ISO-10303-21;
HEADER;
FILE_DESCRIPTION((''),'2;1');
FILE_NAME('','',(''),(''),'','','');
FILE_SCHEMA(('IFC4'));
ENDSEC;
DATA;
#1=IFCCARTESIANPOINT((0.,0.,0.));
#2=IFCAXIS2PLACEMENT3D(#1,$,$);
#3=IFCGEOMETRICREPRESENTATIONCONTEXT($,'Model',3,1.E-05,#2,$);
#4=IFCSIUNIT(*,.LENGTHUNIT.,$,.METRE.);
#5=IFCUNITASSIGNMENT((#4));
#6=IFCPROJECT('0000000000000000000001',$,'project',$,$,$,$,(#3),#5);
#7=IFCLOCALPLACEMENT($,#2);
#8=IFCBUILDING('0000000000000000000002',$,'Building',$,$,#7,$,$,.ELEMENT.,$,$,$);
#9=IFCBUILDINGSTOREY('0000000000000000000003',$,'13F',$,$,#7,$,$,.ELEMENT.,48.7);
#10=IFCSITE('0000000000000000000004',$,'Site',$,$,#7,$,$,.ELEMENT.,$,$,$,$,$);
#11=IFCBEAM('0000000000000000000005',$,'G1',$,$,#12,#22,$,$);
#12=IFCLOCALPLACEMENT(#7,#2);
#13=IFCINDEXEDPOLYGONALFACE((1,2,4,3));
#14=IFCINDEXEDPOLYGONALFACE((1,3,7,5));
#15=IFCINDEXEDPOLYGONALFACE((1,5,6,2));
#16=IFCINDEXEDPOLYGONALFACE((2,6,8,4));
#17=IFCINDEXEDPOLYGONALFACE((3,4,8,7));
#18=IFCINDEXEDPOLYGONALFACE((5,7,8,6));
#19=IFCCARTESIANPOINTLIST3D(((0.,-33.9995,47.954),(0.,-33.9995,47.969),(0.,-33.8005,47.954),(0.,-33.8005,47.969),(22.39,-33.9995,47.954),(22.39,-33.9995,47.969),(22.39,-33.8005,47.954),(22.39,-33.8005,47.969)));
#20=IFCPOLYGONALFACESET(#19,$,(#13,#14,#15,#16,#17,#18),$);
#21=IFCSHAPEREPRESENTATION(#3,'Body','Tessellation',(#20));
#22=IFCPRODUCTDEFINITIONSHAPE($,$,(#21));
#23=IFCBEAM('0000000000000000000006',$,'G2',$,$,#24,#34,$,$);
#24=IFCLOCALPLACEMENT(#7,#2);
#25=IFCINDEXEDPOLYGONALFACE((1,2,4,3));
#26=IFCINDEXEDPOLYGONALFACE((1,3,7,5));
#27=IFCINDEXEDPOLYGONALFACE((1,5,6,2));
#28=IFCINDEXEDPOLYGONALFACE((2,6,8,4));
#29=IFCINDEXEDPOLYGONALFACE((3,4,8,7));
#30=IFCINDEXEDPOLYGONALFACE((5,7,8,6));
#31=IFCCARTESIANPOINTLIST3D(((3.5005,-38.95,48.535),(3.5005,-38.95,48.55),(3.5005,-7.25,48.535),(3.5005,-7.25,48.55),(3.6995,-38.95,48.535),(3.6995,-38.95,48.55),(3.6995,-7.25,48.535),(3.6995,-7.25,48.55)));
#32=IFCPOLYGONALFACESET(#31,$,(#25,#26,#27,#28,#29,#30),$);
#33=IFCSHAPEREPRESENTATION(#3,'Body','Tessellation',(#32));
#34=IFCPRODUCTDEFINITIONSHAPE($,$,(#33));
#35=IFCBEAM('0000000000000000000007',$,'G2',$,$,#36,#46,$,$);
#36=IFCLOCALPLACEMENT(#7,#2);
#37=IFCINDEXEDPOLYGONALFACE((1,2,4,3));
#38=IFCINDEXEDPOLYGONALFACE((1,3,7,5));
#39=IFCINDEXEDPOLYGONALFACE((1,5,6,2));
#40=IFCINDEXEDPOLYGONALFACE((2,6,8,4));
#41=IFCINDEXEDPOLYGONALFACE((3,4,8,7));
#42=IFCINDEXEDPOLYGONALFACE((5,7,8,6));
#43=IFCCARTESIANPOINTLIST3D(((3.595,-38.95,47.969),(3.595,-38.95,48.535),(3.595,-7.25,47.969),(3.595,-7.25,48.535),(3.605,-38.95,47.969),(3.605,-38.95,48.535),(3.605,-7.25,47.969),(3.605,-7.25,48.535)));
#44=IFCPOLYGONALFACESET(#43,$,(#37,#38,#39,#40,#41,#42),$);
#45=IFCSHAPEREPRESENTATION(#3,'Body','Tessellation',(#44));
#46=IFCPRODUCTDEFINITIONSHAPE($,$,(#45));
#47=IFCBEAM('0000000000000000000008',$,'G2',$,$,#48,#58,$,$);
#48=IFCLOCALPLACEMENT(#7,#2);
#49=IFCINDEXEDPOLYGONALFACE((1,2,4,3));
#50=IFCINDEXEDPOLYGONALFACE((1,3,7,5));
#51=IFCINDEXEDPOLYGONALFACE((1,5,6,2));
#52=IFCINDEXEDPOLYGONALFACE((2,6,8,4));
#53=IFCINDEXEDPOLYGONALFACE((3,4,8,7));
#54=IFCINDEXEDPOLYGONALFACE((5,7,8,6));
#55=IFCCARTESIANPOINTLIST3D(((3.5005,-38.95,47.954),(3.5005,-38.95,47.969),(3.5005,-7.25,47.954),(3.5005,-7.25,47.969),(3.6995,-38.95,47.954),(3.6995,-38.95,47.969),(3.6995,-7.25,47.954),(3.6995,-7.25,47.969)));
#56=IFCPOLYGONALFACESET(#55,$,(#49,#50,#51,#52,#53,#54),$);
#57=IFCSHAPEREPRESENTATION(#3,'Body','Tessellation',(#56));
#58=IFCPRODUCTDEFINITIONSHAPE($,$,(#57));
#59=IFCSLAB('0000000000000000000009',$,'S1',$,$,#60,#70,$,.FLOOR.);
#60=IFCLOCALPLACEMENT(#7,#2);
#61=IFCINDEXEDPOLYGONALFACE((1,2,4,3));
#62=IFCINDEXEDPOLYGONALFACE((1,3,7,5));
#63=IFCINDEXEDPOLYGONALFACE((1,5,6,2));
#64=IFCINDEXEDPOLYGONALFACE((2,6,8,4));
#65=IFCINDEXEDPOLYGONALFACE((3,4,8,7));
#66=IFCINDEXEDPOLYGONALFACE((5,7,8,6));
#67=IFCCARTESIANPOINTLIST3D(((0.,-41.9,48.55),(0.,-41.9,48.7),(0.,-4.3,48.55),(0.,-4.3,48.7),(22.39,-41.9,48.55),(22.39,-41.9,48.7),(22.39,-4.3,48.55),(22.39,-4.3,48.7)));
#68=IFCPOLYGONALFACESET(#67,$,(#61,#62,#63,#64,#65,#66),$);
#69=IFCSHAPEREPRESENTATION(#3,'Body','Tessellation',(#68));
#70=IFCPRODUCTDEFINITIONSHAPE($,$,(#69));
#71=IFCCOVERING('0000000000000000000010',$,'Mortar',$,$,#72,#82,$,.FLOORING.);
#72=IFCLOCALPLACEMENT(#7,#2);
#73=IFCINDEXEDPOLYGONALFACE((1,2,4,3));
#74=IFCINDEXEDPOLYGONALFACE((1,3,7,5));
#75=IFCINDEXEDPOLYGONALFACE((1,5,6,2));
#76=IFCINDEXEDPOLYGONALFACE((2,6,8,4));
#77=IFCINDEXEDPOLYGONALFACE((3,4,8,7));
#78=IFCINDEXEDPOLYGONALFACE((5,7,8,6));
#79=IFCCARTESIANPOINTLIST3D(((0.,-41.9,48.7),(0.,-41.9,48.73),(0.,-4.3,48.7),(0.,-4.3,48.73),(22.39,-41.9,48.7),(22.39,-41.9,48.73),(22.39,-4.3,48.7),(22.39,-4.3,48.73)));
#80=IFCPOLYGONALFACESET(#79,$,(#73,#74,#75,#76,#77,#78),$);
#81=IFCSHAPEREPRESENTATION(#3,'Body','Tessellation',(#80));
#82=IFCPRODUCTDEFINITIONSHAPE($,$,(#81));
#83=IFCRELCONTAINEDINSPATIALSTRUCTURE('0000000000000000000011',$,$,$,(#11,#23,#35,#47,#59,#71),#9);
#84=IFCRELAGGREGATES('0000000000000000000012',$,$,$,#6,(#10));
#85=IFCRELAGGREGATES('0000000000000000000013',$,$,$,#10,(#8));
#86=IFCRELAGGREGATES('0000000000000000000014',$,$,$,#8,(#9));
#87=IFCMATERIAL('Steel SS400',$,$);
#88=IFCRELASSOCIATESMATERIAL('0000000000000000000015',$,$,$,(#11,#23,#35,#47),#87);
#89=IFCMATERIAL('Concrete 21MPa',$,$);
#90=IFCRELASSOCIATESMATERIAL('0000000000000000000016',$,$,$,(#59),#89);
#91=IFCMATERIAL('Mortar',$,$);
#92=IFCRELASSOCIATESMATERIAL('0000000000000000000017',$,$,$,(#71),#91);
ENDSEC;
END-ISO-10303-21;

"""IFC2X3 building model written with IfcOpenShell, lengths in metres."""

from ifc_helpers import new_model, si_unit, frame, origin, origin_2d, place, context, project, spatial, rectangle, extrude, material, element, save


model = new_model("IFC2X3")

# Units and contexts
model_context = context("Model", 3, precision=1e-05, world=origin())
ifc_project = project(units=[si_unit("LENGTHUNIT", "METRE")], contexts=[model_context])

# Site, building, storey
placement = place(None, origin())
site = spatial("IfcSite", under=ifc_project, at=placement, Name="Site", CompositionType="ELEMENT")
building = spatial("IfcBuilding", under=site, at=placement, Name="Building", CompositionType="ELEMENT")
storey = spatial("IfcBuildingStorey", under=building, at=placement, Name="13F", CompositionType="ELEMENT", Elevation=48.7)

# Shared definitions
ifc_material_1 = material(Name="Concrete 21MPa")
ifc_material_2 = material(Name="Steel SS400")

# Beams
beam_1_placement = place(None, frame((11.195, -33.9, 47.954)))
element("IfcBeam", 1, at=beam_1_placement, inside=storey, material=ifc_material_2, Name="G1", context=model_context, shape_type="SweptSolid", body=[
    extrude(rectangle(XDim=22.39, YDim=0.199, at=origin_2d()), origin(), (0.0, 0.0, 1.0), 0.015),
])
beam_2_placement = place(None, frame((3.6, -23.1, 48.535)))
element("IfcBeam", 2, at=beam_2_placement, inside=storey, material=ifc_material_2, Name="G2", context=model_context, shape_type="SweptSolid", body=[
    extrude(rectangle(XDim=0.199, YDim=31.7, at=origin_2d()), origin(), (0.0, 0.0, 1.0), 0.015),
])
beam_3_placement = place(None, frame((3.6, -23.1, 47.969)))
element("IfcBeam", 3, at=beam_3_placement, inside=storey, material=ifc_material_2, Name="G2", context=model_context, shape_type="SweptSolid", body=[
    extrude(rectangle(XDim=0.01, YDim=31.7, at=origin_2d()), origin(), (0.0, 0.0, 1.0), 0.566),
])
beam_4_placement = place(None, frame((3.6, -23.1, 47.954)))
element("IfcBeam", 4, at=beam_4_placement, inside=storey, material=ifc_material_2, Name="G2", context=model_context, shape_type="SweptSolid", body=[
    extrude(rectangle(XDim=0.199, YDim=31.7, at=origin_2d()), origin(), (0.0, 0.0, 1.0), 0.015),
])

# Slab
slab_placement = place(None, frame((11.195, -23.1, 48.55)))
element("IfcSlab", 5, at=slab_placement, inside=storey, material=ifc_material_1, Name="S1", PredefinedType="FLOOR", context=model_context, shape_type="SweptSolid", body=[
    extrude(rectangle(XDim=22.39, YDim=37.6, at=origin_2d()), origin(), (0.0, 0.0, 1.0), 0.15),
])

# Covering
ifc_material_3 = material(Name="Mortar")
covering_placement = place(None, frame((11.195, -23.1, 48.7)))
element("IfcCovering", 6, at=covering_placement, inside=storey, material=ifc_material_3, Name="Mortar", PredefinedType="FLOORING", context=model_context, shape_type="SweptSolid", body=[
    extrude(rectangle(XDim=22.39, YDim=37.6, at=origin_2d()), origin(), (0.0, 0.0, 1.0), 0.03),
])

save(model, "model.ifc")
